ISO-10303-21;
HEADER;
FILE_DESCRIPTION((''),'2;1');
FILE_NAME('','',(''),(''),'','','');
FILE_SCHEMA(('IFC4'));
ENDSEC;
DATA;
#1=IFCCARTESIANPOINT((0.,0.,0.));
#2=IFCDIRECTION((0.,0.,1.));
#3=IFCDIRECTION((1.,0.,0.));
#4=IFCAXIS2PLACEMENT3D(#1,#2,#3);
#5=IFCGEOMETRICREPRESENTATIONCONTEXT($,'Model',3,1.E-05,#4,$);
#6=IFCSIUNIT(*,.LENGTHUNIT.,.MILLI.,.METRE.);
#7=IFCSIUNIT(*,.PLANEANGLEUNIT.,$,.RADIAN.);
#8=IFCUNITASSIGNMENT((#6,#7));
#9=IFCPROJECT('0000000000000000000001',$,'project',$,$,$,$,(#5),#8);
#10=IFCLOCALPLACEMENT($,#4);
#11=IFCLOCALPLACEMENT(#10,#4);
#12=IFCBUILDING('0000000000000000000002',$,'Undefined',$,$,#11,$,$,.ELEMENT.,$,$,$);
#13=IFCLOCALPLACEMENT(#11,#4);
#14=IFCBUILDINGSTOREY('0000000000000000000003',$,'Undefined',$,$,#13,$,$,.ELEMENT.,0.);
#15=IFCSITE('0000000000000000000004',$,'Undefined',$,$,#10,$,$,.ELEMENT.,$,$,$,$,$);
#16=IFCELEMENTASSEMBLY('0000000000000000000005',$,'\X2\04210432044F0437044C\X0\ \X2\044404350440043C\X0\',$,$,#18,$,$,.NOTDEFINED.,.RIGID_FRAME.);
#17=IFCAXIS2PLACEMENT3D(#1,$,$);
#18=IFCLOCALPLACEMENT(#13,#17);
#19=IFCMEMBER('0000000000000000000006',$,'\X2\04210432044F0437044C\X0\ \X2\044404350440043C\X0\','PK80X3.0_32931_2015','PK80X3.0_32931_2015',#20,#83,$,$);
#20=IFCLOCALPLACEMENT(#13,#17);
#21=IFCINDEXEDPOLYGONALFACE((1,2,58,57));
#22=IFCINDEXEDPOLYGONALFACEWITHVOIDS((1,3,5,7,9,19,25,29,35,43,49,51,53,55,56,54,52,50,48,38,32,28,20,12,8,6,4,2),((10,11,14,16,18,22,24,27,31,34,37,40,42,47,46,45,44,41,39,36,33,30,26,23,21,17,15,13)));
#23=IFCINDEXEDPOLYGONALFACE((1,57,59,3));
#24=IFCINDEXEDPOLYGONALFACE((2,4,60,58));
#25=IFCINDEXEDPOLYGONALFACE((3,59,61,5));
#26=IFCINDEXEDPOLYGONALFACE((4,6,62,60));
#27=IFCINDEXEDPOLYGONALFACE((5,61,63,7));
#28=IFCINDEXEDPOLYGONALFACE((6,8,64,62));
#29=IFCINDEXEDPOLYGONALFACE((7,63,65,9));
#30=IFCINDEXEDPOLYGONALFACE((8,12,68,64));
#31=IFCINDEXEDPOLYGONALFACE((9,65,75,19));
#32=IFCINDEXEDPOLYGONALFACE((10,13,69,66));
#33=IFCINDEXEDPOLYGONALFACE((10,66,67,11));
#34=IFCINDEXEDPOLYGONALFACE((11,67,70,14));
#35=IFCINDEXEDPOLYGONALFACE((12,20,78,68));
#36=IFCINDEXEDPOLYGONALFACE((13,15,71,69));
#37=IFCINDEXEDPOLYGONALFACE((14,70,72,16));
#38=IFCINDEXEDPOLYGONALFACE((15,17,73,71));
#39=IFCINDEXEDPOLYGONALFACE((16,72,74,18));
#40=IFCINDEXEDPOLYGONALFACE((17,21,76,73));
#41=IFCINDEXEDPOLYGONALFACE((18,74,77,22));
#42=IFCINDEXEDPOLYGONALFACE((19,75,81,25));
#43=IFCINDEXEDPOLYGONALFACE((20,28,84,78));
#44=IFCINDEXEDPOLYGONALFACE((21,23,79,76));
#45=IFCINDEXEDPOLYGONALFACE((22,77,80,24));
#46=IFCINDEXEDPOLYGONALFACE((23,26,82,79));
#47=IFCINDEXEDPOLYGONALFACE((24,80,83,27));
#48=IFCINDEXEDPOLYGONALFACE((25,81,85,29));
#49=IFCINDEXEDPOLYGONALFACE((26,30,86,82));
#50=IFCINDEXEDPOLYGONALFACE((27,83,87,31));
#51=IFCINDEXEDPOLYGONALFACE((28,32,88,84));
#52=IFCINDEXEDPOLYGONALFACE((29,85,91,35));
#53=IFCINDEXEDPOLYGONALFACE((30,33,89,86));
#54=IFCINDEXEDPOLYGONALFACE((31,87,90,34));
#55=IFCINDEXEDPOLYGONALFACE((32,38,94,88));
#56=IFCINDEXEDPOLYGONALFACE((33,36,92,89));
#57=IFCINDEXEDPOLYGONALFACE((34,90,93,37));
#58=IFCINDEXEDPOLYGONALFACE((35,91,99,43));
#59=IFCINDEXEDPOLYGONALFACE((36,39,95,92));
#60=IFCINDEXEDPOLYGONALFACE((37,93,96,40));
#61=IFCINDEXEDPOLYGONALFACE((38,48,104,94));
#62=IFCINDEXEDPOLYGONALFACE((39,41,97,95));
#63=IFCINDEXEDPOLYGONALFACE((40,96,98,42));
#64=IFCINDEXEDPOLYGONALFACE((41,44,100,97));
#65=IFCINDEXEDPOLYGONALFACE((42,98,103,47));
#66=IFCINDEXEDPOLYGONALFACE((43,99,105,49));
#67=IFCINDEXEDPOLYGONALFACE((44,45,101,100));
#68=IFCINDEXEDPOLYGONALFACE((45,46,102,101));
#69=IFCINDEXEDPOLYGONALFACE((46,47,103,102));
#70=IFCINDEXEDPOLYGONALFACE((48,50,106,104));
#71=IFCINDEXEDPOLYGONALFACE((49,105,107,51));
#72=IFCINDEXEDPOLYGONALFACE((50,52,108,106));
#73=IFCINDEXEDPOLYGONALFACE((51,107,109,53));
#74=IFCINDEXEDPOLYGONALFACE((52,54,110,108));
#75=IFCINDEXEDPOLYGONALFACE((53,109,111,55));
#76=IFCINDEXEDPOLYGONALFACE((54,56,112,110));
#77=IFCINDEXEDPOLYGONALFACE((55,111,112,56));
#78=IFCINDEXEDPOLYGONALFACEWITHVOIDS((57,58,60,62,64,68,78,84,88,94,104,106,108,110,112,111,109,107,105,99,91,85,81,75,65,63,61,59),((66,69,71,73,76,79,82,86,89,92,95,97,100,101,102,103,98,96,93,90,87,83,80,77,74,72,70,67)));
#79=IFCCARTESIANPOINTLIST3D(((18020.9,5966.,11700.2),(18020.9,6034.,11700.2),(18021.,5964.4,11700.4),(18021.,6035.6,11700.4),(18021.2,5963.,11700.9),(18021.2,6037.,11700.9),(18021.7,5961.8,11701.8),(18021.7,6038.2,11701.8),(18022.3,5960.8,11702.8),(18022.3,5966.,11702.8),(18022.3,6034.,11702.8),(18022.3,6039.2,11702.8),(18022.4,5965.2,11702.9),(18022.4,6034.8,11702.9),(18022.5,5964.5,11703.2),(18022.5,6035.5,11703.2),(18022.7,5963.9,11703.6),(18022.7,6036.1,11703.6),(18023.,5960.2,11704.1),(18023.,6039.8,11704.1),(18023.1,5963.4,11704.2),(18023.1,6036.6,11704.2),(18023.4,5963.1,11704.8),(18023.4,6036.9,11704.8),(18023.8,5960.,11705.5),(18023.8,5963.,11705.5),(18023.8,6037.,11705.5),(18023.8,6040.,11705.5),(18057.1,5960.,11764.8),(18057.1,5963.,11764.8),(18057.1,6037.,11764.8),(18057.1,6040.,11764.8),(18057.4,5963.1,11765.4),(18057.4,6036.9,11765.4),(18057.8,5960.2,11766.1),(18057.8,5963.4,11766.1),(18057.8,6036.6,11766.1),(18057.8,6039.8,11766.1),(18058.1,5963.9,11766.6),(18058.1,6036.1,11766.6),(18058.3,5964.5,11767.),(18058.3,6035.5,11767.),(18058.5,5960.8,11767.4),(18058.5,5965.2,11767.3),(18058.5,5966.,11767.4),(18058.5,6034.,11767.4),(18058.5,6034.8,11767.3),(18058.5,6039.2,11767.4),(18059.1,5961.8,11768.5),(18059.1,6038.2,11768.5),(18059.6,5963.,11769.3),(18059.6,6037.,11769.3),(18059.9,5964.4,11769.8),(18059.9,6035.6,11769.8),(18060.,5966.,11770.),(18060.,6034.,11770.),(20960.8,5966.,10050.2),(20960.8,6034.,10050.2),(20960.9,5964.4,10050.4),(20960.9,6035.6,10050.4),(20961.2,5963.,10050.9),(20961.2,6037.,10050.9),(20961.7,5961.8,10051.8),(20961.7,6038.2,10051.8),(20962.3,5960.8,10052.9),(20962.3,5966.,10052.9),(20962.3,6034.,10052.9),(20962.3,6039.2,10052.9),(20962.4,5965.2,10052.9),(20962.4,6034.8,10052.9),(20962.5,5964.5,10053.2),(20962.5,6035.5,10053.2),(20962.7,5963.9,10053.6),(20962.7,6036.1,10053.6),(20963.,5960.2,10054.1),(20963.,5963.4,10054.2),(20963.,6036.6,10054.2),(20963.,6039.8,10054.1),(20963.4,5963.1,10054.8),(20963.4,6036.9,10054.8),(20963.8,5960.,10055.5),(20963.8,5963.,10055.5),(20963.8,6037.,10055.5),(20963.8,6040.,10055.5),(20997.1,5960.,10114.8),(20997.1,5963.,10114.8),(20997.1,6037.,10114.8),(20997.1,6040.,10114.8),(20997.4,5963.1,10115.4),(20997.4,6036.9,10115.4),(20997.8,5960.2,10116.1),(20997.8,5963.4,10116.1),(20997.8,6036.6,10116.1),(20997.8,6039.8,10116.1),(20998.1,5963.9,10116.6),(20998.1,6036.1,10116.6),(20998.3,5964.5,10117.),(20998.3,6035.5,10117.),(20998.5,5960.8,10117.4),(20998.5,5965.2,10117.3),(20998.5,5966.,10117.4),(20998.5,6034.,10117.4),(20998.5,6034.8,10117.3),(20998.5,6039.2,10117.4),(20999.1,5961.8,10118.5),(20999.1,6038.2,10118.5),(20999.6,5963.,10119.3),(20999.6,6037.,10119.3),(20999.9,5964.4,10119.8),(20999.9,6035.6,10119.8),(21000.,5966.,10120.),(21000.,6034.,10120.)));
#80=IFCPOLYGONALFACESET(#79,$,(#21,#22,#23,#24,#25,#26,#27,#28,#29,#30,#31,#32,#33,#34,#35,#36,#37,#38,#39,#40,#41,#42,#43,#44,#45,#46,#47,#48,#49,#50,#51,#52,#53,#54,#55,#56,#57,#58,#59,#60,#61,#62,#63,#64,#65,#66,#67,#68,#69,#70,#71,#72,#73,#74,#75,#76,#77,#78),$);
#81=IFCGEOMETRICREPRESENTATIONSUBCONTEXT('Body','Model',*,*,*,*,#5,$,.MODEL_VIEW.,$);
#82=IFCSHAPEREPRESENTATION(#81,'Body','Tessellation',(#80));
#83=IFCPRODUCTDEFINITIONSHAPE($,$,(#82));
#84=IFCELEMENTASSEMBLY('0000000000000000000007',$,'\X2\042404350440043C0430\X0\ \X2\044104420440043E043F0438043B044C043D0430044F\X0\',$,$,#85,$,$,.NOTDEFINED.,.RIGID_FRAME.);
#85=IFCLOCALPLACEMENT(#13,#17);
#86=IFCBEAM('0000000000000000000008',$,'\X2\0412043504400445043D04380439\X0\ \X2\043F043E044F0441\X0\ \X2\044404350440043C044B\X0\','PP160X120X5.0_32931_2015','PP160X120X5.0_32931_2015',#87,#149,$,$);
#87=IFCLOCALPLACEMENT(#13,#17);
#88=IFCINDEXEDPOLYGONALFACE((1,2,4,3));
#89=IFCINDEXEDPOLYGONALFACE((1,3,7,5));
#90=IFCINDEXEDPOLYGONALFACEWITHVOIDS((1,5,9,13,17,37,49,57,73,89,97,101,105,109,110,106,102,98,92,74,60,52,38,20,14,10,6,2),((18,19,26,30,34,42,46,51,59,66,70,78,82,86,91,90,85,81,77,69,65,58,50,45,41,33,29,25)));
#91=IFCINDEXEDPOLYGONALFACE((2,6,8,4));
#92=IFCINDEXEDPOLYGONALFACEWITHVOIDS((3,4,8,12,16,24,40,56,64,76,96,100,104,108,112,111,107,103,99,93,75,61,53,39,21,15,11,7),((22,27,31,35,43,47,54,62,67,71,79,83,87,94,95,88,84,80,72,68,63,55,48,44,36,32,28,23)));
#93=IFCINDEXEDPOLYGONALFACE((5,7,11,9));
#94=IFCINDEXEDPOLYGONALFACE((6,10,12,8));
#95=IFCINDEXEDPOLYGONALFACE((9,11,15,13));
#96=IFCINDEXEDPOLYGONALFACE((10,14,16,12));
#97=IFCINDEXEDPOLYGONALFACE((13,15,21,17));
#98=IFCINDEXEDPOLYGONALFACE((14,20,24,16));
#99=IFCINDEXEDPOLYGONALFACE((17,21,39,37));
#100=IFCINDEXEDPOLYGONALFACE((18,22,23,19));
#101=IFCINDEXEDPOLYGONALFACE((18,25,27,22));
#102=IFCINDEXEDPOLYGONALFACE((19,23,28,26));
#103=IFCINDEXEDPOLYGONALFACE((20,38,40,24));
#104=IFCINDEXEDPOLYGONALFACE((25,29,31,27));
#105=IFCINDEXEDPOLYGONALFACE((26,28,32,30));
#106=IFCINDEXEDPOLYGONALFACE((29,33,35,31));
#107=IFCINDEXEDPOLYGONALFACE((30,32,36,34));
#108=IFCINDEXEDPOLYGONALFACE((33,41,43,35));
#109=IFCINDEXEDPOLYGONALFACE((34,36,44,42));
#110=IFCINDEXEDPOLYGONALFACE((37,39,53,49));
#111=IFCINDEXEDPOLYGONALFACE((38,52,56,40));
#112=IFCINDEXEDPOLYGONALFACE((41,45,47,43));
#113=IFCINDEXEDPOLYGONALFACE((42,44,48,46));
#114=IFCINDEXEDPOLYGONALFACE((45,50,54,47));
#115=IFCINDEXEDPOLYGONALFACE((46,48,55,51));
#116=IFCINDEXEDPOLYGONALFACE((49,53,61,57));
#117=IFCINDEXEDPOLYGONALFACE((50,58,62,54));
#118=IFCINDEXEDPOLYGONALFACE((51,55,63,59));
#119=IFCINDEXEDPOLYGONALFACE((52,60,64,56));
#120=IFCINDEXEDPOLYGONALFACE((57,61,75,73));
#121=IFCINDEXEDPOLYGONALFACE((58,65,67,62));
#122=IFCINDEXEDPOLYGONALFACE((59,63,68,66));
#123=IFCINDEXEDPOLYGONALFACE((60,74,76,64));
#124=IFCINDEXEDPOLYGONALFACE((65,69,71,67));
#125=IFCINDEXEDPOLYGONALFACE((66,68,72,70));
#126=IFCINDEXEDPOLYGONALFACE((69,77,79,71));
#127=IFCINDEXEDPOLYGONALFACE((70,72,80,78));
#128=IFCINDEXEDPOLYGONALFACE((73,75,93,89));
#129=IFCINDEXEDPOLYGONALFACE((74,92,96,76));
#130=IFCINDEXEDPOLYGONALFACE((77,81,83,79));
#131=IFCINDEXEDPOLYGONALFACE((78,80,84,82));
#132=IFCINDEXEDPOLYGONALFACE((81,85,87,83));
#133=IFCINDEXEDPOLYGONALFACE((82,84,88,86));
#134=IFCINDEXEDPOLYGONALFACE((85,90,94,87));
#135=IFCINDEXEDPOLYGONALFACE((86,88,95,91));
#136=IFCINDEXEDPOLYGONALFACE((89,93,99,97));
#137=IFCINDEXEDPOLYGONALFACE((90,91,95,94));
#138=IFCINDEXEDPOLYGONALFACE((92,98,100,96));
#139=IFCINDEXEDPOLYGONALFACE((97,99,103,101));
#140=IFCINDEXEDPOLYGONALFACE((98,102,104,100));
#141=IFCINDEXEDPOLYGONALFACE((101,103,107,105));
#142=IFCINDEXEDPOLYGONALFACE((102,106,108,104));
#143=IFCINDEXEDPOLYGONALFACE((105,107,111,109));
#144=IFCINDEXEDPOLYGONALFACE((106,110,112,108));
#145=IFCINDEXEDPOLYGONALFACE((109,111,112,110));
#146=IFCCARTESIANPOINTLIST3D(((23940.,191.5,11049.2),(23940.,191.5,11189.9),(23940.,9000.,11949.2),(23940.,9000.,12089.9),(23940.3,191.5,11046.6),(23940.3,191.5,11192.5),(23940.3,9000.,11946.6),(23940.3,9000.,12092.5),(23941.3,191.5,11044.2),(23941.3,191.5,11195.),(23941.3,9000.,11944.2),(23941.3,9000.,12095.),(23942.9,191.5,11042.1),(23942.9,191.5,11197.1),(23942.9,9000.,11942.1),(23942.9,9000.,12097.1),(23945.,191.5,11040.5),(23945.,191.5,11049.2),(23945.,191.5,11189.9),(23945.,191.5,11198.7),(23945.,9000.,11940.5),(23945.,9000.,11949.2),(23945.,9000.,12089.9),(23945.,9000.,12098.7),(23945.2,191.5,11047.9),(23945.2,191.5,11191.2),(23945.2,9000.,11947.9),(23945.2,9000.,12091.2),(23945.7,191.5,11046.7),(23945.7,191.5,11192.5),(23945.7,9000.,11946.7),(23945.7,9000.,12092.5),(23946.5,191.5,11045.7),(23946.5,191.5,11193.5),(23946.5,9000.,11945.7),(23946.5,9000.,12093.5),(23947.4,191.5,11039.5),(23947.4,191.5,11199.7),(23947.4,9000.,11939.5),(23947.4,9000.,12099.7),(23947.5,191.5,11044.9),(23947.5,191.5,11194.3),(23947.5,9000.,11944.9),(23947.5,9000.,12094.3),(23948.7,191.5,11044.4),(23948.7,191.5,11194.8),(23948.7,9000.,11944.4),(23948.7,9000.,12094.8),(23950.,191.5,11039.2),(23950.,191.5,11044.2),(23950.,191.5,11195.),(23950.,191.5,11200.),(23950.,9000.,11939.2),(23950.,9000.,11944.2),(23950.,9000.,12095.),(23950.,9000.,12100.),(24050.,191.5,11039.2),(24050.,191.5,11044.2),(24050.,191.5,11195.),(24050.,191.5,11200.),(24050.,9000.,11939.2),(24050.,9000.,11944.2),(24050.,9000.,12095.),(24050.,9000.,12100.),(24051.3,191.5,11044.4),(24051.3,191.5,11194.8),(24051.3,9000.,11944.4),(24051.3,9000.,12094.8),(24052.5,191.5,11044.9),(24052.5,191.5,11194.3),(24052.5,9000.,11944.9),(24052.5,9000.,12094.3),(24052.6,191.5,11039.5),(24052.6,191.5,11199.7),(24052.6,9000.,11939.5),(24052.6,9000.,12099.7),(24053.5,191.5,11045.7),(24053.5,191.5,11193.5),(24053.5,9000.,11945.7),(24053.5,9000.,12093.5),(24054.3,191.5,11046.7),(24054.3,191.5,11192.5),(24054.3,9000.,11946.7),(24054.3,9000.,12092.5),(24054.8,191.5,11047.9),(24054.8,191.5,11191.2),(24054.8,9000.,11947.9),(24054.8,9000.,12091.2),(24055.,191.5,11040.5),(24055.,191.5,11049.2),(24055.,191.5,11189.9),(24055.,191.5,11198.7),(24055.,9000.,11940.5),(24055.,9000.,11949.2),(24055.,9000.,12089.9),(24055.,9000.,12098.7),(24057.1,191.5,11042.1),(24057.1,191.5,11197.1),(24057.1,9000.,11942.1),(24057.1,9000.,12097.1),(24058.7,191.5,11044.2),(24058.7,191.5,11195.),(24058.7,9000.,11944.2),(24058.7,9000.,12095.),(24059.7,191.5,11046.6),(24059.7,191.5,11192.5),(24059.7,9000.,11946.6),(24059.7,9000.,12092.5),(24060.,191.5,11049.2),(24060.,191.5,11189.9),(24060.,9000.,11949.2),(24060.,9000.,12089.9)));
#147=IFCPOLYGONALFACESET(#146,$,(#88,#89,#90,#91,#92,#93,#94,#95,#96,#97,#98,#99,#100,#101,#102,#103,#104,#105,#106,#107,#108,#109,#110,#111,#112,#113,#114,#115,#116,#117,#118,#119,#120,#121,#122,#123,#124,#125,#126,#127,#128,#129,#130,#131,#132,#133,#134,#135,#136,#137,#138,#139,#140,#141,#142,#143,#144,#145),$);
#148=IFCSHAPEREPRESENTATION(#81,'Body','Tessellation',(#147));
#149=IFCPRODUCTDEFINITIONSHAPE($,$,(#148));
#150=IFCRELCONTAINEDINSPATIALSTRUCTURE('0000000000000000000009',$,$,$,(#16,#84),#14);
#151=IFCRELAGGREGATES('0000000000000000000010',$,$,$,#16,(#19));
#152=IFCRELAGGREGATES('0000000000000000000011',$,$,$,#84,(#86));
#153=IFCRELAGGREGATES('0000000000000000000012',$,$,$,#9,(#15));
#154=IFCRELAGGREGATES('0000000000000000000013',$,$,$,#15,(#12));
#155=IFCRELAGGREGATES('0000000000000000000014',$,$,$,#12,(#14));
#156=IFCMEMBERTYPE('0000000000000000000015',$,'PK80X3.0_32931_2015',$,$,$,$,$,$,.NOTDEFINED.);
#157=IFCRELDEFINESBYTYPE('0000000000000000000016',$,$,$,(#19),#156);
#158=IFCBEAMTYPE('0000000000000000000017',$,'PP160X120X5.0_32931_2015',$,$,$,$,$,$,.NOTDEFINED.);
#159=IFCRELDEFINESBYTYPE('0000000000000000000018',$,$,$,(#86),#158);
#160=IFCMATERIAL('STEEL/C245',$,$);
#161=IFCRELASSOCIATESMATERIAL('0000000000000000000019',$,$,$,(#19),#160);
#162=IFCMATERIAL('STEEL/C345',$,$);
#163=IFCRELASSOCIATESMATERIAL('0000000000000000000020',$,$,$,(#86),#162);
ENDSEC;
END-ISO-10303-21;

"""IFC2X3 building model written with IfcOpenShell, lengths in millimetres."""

from ifc_helpers import new_model, si_unit, frame, origin_with_axes, origin_2d_with_axis, place, context, subcontext, project, spatial, hollow_rectangle, extrude, clip, halfspace, material, type_object, element, aggregate, save


model = new_model("IFC2X3")

# Units and contexts
model_context = context("Model", 3, precision=1e-05, world=origin_with_axes())
body_context = subcontext(model_context, "Body", "Model", "MODEL_VIEW")
ifc_project = project(units=[si_unit("LENGTHUNIT", "METRE", prefix="MILLI"), si_unit("PLANEANGLEUNIT", "RADIAN")], contexts=[model_context])

# Site, building, storey
site_placement = place(None, origin_with_axes())
site = spatial("IfcSite", under=ifc_project, at=site_placement, Name="Undefined", CompositionType="ELEMENT")
building_placement = place(site_placement, origin_with_axes())
building = spatial("IfcBuilding", under=site, at=building_placement, Name="Undefined", CompositionType="ELEMENT")
storey_placement = place(building_placement, origin_with_axes())
storey = spatial("IfcBuildingStorey", under=building, at=storey_placement, Name="Undefined", CompositionType="ELEMENT", Elevation=0.0)

# Shared definitions
ifc_material_1 = material(Name="STEEL/C245")
ifc_material_2 = material(Name="STEEL/C345")

# Element assembly, member
assembly_1_placement = place(storey_placement, origin_with_axes())
assembly_1 = element("IfcElementAssembly", 1, at=assembly_1_placement, inside=storey, Name="Связь ферм", AssemblyPlace="NOTDEFINED", PredefinedType="RIGID_FRAME")
member_type_1 = type_object("IfcMemberType", Name="PK80X3.0_32931_2015", PredefinedType="NOTDEFINED")
member_1_placement = place(assembly_1_placement, frame((18040.4, 6000.0, 11735.1), z_axis=(0.489416, 0.0, 0.87205), x_axis=(0.87205, 0.0, -0.489416)))
member_1 = element("IfcMember", 2, at=member_1_placement, type_object=member_type_1, material=ifc_material_1, Name="Связь ферм", Description="PK80X3.0_32931_2015", ObjectType="PK80X3.0_32931_2015", context=body_context, shape_type="SweptSolid", body=[
    extrude(hollow_rectangle(XDim=80.0, YDim=80.0, WallThickness=3.0, InnerFilletRadius=3.0, OuterFilletRadius=6.0, at=origin_2d_with_axis()), frame((3371.4, 0.0, 0.0), z_axis=(-1.0, 0.0, 0.0), x_axis=(0.0, -1.0, 0.0)), (0.0, 0.0, 1.0), 3371.4),
])
aggregate(assembly_1, [member_1])

# Element assembly
assembly_2_placement = place(storey_placement, origin_with_axes())
assembly_2 = element("IfcElementAssembly", 3, at=assembly_2_placement, inside=storey, Name="Ферма стропильная", AssemblyPlace="NOTDEFINED", PredefinedType="RIGID_FRAME")

# Beam
beam_type_1 = type_object("IfcBeamType", Name="PP160X120X5.0_32931_2015", PredefinedType="NOTDEFINED")
beam_1_placement = place(assembly_2_placement, frame((24000.0, 199.6, 11120.4), z_axis=(0.0, -0.101645, 0.994821), x_axis=(0.0, 0.994821, 0.101645)))
beam_1 = element("IfcBeam", 4, at=beam_1_placement, type_object=beam_type_1, material=ifc_material_2, Name="Верхний пояс фермы", Description="PP160X120X5.0_32931_2015", ObjectType="PP160X120X5.0_32931_2015", context=body_context, shape_type="Clipping", body=[
    clip(clip(extrude(hollow_rectangle(XDim=120.0, YDim=160.0, WallThickness=5.0, InnerFilletRadius=5.0, OuterFilletRadius=10.0, at=origin_2d_with_axis()), frame((8862.7, 0.0, 0.0), z_axis=(-1.0, 0.0, 0.0), x_axis=(0.0, -1.0, 0.0)), (0.0, 0.0, 1.0), 8887.4), halfspace(frame((8854.4, 0.0, 80.0), z_axis=(0.994821, 0.0, -0.101645), x_axis=(0.0, -1.0, 0.0)), False)), halfspace(frame((0.0, 0.0, 80.0), z_axis=(0.994821, 0.0, -0.101645), x_axis=(0.0, -1.0, 0.0)), True)),
])
aggregate(assembly_2, [beam_1])

save(model, "model.ifc")
